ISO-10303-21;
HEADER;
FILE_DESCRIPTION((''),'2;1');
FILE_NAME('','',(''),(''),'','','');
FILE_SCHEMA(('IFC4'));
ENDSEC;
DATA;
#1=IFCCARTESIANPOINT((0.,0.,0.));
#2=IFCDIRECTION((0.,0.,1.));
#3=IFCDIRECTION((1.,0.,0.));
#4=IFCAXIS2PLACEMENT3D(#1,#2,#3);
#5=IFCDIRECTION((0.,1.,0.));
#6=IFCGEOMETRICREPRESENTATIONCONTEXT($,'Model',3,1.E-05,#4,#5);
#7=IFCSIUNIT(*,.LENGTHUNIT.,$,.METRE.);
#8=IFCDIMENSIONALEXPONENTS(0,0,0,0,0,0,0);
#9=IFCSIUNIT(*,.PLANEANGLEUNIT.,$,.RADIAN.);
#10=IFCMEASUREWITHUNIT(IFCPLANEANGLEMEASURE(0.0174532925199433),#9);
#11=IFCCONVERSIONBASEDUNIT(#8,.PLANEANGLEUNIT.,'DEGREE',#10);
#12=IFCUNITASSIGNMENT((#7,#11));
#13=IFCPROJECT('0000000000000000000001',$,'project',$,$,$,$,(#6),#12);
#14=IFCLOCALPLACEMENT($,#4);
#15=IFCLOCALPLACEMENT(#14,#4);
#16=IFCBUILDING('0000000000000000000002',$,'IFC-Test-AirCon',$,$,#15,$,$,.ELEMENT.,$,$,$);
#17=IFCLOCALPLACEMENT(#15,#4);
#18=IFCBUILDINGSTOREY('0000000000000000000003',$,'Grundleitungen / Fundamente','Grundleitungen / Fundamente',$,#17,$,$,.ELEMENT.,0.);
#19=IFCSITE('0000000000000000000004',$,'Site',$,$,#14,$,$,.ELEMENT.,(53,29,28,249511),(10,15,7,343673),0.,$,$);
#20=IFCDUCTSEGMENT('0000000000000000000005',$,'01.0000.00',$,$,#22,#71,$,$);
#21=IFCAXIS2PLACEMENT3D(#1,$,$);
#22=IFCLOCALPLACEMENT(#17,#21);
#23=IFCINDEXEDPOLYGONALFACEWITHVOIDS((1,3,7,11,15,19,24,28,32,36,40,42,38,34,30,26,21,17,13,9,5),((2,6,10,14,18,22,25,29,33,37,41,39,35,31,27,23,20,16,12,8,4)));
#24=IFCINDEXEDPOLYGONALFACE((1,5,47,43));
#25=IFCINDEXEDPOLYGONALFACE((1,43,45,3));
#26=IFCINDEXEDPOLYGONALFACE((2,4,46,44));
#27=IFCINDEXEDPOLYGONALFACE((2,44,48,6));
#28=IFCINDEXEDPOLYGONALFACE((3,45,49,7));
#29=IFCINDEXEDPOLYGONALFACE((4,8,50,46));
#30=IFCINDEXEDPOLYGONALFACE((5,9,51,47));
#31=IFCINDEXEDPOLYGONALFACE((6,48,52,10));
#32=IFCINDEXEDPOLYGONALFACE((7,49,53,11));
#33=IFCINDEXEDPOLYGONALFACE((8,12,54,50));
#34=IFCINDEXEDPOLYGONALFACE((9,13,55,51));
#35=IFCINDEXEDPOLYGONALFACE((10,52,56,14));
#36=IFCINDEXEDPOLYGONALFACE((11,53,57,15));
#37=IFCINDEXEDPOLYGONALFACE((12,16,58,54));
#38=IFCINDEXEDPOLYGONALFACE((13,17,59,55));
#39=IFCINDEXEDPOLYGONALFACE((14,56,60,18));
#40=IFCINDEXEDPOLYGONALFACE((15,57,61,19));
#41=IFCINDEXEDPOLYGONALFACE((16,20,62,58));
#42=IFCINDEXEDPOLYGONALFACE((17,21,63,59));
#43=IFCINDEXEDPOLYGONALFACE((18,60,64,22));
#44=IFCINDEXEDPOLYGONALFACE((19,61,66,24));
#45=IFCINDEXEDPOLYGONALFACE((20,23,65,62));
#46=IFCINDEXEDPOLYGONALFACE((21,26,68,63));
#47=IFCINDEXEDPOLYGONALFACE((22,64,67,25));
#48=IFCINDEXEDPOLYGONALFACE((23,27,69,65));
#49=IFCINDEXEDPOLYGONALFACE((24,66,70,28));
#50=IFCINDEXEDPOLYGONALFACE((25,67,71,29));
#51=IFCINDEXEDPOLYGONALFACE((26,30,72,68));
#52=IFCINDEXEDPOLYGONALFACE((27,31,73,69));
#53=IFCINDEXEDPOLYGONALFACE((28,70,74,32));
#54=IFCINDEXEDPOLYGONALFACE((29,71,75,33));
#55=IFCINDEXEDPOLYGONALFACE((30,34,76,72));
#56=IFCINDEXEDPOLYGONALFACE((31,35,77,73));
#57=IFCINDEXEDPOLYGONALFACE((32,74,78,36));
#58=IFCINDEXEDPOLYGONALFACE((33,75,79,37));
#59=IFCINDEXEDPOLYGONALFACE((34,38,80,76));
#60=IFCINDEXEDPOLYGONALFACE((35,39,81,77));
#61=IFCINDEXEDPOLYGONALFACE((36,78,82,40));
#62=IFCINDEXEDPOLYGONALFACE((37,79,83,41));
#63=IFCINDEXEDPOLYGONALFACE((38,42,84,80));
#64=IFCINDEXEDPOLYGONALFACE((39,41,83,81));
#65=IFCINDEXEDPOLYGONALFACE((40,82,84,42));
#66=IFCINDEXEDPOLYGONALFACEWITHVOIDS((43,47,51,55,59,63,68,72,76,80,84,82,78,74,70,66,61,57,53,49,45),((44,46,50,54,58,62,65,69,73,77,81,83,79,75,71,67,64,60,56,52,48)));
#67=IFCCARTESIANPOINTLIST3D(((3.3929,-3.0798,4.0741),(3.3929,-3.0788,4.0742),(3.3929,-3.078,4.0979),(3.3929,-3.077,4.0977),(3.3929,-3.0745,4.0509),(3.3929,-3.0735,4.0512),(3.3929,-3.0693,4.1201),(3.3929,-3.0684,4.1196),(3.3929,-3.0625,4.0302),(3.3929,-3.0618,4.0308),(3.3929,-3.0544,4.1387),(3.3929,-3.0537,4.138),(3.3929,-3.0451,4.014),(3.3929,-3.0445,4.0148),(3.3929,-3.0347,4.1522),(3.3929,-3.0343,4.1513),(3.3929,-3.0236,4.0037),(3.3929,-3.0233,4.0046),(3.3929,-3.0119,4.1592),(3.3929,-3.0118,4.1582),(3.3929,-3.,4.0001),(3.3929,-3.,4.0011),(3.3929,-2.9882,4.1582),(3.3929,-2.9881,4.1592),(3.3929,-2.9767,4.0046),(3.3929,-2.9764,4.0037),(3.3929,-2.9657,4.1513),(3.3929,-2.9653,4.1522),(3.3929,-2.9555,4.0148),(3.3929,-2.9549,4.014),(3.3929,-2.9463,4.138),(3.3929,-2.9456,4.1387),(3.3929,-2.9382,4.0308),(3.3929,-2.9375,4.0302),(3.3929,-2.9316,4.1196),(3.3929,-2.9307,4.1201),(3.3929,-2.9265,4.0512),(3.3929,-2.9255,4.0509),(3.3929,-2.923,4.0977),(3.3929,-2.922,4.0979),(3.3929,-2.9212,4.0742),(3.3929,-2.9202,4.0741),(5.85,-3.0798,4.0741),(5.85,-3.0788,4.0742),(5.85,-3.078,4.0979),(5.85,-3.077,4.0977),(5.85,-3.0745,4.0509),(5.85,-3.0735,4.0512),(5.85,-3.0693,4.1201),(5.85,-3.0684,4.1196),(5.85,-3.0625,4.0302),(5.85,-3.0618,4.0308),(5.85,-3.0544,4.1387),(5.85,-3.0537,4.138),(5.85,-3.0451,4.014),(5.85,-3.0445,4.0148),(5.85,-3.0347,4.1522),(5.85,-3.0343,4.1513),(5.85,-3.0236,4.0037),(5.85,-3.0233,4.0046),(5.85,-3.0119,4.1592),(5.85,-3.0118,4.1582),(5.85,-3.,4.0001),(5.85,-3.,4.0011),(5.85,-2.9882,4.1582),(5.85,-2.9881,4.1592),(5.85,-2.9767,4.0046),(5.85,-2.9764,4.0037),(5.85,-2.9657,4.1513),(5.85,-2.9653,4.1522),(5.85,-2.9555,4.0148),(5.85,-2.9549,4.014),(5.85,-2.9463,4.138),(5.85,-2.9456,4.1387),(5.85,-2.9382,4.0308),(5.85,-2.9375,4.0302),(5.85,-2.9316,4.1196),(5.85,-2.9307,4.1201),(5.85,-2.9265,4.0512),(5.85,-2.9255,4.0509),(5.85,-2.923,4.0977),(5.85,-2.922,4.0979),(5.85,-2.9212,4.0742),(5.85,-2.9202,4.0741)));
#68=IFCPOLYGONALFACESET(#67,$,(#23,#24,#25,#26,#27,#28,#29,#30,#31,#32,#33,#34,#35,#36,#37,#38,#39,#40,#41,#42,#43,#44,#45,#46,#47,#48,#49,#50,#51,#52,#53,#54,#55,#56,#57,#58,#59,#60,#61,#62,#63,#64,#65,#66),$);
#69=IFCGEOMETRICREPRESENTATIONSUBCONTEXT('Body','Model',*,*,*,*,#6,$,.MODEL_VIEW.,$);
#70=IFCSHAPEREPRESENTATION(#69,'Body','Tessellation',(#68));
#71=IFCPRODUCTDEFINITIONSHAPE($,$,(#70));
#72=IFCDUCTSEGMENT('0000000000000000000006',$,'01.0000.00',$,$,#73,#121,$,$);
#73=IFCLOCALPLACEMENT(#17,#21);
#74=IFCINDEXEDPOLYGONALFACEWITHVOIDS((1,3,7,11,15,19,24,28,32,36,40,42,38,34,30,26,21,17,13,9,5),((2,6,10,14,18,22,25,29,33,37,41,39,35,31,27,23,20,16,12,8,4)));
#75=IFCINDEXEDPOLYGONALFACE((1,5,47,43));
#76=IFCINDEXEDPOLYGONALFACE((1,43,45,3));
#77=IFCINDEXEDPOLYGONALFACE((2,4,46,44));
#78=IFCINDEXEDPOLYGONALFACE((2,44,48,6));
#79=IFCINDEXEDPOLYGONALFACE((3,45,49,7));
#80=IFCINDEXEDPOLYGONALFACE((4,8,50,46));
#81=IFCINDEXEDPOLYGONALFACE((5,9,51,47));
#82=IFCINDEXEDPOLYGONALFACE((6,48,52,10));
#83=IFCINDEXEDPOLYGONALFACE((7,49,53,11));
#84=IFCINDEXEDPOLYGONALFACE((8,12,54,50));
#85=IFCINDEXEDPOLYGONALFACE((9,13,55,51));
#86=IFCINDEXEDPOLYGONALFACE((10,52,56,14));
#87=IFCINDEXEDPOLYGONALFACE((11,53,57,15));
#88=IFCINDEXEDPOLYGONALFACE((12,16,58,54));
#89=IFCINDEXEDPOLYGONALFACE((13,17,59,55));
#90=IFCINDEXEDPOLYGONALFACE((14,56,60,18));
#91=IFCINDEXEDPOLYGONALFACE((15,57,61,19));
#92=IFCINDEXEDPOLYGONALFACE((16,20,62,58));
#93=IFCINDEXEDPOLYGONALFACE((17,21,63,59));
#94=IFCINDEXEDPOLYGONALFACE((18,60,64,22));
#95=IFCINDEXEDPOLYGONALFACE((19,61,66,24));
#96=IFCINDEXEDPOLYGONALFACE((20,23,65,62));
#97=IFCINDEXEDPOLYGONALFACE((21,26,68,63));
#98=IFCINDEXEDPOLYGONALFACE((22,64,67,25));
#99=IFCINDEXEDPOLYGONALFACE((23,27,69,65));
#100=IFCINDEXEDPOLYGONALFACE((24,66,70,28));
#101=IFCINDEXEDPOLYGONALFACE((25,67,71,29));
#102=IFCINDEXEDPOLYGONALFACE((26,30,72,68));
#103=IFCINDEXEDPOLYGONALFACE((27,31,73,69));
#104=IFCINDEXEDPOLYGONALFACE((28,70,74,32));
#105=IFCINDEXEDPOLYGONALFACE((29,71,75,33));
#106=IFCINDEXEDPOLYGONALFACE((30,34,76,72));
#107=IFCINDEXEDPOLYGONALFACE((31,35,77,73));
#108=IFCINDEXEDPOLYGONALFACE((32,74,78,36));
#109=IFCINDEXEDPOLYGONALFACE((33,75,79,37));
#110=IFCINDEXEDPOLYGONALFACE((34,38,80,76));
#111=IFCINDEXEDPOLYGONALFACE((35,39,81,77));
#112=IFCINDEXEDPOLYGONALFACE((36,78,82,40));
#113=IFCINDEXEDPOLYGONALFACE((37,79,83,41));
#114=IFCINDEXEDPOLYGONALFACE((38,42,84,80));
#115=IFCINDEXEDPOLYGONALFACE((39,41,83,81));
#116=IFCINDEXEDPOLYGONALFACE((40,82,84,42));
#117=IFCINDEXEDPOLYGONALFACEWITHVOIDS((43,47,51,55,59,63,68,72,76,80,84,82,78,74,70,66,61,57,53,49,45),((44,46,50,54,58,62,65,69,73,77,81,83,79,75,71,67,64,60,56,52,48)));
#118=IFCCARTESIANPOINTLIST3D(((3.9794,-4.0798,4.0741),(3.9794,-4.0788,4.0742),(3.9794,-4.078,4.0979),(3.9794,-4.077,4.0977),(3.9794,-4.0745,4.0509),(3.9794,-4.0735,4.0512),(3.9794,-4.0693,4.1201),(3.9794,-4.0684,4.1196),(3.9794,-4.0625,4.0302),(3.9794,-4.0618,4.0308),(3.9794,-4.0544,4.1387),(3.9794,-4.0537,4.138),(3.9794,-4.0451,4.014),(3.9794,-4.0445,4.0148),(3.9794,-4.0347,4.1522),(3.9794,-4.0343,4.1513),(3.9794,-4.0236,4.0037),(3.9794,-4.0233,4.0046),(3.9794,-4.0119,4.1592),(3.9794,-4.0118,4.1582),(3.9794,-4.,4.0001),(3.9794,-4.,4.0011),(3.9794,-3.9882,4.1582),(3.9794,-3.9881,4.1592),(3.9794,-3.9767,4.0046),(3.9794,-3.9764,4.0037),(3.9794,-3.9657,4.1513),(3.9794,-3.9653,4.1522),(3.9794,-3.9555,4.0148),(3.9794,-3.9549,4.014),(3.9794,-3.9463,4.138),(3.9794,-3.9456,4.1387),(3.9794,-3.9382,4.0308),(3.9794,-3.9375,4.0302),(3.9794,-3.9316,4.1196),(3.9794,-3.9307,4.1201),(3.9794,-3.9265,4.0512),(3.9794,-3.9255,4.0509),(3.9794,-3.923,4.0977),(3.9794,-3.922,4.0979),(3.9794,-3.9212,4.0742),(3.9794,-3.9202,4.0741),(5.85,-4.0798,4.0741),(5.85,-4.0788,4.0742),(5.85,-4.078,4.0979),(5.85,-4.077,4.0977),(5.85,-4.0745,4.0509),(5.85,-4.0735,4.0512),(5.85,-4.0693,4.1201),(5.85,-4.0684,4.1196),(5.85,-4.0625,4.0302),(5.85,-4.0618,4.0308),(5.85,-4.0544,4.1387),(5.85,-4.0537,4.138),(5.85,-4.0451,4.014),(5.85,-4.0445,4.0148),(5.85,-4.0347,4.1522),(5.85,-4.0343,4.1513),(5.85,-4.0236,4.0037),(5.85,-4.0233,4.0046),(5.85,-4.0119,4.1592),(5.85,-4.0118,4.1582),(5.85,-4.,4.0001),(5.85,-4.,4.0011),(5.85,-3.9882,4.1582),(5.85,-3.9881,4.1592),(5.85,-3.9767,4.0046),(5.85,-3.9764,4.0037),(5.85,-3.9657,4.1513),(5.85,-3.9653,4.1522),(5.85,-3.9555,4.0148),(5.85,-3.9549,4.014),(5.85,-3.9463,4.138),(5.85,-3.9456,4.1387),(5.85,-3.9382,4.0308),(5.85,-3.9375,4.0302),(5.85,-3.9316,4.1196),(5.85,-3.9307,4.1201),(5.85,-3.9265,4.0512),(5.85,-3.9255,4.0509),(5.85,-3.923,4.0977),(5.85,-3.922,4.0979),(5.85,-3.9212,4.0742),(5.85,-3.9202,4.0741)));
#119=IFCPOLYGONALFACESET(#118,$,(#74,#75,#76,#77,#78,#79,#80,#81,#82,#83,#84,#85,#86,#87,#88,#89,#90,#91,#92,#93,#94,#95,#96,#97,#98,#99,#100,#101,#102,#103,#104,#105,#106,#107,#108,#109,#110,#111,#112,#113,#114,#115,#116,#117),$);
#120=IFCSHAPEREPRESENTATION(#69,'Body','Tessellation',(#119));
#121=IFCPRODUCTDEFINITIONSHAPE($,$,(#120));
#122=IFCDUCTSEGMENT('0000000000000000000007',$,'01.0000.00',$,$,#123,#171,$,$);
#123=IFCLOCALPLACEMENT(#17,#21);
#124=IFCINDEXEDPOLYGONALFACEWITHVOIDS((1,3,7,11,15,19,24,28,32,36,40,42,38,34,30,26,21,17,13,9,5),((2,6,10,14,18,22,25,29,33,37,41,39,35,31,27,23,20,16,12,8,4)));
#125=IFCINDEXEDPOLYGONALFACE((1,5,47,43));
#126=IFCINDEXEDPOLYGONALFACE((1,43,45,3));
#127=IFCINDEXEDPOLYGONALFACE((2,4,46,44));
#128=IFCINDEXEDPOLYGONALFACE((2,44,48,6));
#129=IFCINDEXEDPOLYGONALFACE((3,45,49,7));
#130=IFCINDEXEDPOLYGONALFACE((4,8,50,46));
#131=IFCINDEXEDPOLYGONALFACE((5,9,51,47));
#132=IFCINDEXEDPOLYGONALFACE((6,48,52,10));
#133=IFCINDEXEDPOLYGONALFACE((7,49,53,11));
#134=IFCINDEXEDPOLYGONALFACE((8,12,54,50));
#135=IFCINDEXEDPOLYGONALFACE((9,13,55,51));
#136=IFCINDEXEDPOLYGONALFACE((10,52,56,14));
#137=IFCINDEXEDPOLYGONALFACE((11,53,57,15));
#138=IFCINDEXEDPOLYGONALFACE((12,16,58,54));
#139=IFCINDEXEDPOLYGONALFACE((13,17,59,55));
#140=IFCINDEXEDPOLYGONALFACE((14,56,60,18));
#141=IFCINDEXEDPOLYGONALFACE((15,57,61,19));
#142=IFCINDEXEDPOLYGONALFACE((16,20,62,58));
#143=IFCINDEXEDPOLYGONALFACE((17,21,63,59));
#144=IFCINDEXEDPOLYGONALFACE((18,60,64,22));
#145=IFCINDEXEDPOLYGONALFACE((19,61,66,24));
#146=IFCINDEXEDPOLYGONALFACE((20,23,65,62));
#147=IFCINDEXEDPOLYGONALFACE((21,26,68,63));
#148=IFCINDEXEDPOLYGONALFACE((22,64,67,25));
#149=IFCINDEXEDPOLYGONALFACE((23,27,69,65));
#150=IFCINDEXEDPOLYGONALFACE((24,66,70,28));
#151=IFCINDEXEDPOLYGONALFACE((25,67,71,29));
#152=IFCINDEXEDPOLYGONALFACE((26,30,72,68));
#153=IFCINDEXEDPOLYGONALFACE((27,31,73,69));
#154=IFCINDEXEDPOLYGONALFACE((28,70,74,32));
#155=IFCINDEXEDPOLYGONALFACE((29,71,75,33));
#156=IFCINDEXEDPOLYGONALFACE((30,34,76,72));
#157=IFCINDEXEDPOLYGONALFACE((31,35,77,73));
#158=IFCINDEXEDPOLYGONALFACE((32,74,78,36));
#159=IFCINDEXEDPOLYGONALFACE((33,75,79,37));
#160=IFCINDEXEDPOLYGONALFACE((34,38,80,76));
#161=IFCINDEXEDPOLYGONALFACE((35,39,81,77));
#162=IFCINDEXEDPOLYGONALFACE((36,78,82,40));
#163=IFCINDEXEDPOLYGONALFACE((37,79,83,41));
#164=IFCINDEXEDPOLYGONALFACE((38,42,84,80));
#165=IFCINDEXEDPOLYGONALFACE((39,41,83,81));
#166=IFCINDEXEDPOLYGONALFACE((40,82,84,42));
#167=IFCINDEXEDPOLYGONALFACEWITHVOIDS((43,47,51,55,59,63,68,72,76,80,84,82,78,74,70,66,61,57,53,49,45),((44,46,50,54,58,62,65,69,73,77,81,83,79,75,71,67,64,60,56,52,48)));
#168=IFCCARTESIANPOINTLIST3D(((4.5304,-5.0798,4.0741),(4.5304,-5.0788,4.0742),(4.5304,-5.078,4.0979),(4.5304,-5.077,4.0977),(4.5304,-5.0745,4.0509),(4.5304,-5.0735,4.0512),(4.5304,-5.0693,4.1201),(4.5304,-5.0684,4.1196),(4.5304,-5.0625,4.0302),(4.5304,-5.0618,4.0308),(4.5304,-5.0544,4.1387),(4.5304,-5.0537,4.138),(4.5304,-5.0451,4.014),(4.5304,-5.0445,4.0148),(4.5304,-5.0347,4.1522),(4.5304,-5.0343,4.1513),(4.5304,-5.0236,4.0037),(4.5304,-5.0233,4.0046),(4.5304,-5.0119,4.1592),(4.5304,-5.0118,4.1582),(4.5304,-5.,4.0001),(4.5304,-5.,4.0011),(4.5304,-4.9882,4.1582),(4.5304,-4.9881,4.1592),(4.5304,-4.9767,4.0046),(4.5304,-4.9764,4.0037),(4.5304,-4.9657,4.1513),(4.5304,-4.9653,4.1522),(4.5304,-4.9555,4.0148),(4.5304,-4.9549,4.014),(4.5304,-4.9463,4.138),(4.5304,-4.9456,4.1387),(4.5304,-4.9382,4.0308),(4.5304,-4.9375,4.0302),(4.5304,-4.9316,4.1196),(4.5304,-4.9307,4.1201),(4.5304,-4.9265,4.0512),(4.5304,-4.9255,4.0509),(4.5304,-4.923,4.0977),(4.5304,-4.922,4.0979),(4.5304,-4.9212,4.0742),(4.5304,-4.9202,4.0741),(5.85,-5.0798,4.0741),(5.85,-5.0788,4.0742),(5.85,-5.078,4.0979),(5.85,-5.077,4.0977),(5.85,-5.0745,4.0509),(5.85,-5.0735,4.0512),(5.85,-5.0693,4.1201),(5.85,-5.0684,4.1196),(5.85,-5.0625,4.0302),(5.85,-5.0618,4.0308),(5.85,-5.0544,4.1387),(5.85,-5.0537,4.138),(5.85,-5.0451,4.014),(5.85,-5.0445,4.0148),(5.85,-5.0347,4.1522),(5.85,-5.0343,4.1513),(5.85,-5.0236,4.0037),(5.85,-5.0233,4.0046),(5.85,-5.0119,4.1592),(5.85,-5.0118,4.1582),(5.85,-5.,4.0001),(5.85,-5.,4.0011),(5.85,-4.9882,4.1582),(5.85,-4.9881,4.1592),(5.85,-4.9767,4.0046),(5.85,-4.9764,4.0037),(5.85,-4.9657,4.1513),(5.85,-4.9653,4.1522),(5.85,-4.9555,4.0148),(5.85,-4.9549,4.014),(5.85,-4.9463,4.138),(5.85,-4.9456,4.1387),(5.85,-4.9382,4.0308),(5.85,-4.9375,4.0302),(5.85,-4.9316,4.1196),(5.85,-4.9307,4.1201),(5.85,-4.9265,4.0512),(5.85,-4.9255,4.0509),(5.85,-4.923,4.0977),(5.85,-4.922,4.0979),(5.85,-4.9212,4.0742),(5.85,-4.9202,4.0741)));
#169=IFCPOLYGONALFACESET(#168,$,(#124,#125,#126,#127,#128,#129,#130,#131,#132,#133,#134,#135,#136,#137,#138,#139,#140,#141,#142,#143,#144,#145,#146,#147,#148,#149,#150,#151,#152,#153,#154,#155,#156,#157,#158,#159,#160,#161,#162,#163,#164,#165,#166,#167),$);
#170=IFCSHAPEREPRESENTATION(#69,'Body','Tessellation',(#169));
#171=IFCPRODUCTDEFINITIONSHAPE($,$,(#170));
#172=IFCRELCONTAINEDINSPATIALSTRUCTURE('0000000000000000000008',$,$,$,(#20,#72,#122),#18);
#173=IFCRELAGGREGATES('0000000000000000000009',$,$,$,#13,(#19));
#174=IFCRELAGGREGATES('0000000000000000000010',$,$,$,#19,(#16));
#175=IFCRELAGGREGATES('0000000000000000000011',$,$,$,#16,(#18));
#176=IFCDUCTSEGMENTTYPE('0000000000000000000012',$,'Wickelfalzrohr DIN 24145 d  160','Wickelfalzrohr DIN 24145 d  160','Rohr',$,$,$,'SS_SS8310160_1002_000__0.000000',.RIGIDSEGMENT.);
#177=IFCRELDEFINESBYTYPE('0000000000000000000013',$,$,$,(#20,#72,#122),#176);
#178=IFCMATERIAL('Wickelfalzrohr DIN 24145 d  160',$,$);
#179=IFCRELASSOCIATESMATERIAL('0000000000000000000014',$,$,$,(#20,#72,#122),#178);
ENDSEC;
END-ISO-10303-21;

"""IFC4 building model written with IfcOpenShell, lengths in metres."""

from ifc_helpers import new_model, entity, si_unit, converted_unit, direction, frame, origin_with_axes, origin_2d_with_axis, place, context, subcontext, project, spatial, hollow_circle, extrude, material, type_object, element, save


model = new_model("IFC4")

# Units and contexts
model_context = context("Model", 3, precision=1e-05, world=origin_with_axes(), true_north=direction((0.0, 1.0, 0.0)))
body_context = subcontext(model_context, "Body", "Model", "MODEL_VIEW")
ifc_project = project(units=[si_unit("LENGTHUNIT", "METRE"), converted_unit("PLANEANGLEUNIT", "DEGREE", entity("IfcPlaneAngleMeasure", 0.0174532925199433), si_unit("PLANEANGLEUNIT", "RADIAN"), dimensions=[0, 0, 0, 0, 0, 0, 0])], contexts=[model_context])

# Site, building, storey
site_placement = place(None, origin_with_axes())
site = spatial("IfcSite", under=ifc_project, at=site_placement, Name="Site", CompositionType="ELEMENT", RefLatitude=(53, 29, 28, 249511), RefLongitude=(10, 15, 7, 343673), RefElevation=0.0)
building_placement = place(site_placement, origin_with_axes())
building = spatial("IfcBuilding", under=site, at=building_placement, Name="IFC-Test-AirCon", CompositionType="ELEMENT")
storey_placement = place(building_placement, origin_with_axes())
storey = spatial("IfcBuildingStorey", under=building, at=storey_placement, Name="Grundleitungen / Fundamente", Description="Grundleitungen / Fundamente", CompositionType="ELEMENT", Elevation=0.0)

# Duct segments
ifc_material_1 = material(Name="Wickelfalzrohr DIN 24145 d  160")
duct_segment_type_1 = type_object("IfcDuctSegmentType", Name="Wickelfalzrohr DIN 24145 d  160", Description="Wickelfalzrohr DIN 24145 d  160", ApplicableOccurrence="Rohr", ElementType="SS_SS8310160_1002_000__0.000000", PredefinedType="RIGIDSEGMENT")
duct_segment_1_placement = place(storey_placement, frame((5.85, -3.0, 4.0801), z_axis=(0.0, 0.0, 1.0), x_axis=(-1.0, 0.0, 0.0)))
element("IfcDuctSegment", 1, at=duct_segment_1_placement, inside=storey, type_object=duct_segment_type_1, material=ifc_material_1, Name="01.0000.00", context=body_context, shape_type="SweptSolid", body=[
    extrude(hollow_circle(Radius=0.08, WallThickness=0.001, at=origin_2d_with_axis()), frame((0.0, 0.0, 0.0), z_axis=(1.0, 0.0, 0.0), x_axis=(0.0, 0.0, -1.0)), (0.0, 0.0, 1.0), 2.4571),
])
duct_segment_2_placement = place(storey_placement, frame((5.85, -4.0, 4.0801), z_axis=(0.0, 0.0, 1.0), x_axis=(-1.0, 0.0, 0.0)))
element("IfcDuctSegment", 2, at=duct_segment_2_placement, inside=storey, type_object=duct_segment_type_1, material=ifc_material_1, Name="01.0000.00", context=body_context, shape_type="SweptSolid", body=[
    extrude(hollow_circle(Radius=0.08, WallThickness=0.001, at=origin_2d_with_axis()), frame((0.0, 0.0, 0.0), z_axis=(1.0, 0.0, 0.0), x_axis=(0.0, 0.0, -1.0)), (0.0, 0.0, 1.0), 1.8706),
])
duct_segment_3_placement = place(storey_placement, frame((5.85, -5.0, 4.0801), z_axis=(0.0, 0.0, 1.0), x_axis=(-1.0, 0.0, 0.0)))
element("IfcDuctSegment", 3, at=duct_segment_3_placement, inside=storey, type_object=duct_segment_type_1, material=ifc_material_1, Name="01.0000.00", context=body_context, shape_type="SweptSolid", body=[
    extrude(hollow_circle(Radius=0.08, WallThickness=0.001, at=origin_2d_with_axis()), frame((0.0, 0.0, 0.0), z_axis=(1.0, 0.0, 0.0), x_axis=(0.0, 0.0, -1.0)), (0.0, 0.0, 1.0), 1.3196),
])

save(model, "model.ifc")
